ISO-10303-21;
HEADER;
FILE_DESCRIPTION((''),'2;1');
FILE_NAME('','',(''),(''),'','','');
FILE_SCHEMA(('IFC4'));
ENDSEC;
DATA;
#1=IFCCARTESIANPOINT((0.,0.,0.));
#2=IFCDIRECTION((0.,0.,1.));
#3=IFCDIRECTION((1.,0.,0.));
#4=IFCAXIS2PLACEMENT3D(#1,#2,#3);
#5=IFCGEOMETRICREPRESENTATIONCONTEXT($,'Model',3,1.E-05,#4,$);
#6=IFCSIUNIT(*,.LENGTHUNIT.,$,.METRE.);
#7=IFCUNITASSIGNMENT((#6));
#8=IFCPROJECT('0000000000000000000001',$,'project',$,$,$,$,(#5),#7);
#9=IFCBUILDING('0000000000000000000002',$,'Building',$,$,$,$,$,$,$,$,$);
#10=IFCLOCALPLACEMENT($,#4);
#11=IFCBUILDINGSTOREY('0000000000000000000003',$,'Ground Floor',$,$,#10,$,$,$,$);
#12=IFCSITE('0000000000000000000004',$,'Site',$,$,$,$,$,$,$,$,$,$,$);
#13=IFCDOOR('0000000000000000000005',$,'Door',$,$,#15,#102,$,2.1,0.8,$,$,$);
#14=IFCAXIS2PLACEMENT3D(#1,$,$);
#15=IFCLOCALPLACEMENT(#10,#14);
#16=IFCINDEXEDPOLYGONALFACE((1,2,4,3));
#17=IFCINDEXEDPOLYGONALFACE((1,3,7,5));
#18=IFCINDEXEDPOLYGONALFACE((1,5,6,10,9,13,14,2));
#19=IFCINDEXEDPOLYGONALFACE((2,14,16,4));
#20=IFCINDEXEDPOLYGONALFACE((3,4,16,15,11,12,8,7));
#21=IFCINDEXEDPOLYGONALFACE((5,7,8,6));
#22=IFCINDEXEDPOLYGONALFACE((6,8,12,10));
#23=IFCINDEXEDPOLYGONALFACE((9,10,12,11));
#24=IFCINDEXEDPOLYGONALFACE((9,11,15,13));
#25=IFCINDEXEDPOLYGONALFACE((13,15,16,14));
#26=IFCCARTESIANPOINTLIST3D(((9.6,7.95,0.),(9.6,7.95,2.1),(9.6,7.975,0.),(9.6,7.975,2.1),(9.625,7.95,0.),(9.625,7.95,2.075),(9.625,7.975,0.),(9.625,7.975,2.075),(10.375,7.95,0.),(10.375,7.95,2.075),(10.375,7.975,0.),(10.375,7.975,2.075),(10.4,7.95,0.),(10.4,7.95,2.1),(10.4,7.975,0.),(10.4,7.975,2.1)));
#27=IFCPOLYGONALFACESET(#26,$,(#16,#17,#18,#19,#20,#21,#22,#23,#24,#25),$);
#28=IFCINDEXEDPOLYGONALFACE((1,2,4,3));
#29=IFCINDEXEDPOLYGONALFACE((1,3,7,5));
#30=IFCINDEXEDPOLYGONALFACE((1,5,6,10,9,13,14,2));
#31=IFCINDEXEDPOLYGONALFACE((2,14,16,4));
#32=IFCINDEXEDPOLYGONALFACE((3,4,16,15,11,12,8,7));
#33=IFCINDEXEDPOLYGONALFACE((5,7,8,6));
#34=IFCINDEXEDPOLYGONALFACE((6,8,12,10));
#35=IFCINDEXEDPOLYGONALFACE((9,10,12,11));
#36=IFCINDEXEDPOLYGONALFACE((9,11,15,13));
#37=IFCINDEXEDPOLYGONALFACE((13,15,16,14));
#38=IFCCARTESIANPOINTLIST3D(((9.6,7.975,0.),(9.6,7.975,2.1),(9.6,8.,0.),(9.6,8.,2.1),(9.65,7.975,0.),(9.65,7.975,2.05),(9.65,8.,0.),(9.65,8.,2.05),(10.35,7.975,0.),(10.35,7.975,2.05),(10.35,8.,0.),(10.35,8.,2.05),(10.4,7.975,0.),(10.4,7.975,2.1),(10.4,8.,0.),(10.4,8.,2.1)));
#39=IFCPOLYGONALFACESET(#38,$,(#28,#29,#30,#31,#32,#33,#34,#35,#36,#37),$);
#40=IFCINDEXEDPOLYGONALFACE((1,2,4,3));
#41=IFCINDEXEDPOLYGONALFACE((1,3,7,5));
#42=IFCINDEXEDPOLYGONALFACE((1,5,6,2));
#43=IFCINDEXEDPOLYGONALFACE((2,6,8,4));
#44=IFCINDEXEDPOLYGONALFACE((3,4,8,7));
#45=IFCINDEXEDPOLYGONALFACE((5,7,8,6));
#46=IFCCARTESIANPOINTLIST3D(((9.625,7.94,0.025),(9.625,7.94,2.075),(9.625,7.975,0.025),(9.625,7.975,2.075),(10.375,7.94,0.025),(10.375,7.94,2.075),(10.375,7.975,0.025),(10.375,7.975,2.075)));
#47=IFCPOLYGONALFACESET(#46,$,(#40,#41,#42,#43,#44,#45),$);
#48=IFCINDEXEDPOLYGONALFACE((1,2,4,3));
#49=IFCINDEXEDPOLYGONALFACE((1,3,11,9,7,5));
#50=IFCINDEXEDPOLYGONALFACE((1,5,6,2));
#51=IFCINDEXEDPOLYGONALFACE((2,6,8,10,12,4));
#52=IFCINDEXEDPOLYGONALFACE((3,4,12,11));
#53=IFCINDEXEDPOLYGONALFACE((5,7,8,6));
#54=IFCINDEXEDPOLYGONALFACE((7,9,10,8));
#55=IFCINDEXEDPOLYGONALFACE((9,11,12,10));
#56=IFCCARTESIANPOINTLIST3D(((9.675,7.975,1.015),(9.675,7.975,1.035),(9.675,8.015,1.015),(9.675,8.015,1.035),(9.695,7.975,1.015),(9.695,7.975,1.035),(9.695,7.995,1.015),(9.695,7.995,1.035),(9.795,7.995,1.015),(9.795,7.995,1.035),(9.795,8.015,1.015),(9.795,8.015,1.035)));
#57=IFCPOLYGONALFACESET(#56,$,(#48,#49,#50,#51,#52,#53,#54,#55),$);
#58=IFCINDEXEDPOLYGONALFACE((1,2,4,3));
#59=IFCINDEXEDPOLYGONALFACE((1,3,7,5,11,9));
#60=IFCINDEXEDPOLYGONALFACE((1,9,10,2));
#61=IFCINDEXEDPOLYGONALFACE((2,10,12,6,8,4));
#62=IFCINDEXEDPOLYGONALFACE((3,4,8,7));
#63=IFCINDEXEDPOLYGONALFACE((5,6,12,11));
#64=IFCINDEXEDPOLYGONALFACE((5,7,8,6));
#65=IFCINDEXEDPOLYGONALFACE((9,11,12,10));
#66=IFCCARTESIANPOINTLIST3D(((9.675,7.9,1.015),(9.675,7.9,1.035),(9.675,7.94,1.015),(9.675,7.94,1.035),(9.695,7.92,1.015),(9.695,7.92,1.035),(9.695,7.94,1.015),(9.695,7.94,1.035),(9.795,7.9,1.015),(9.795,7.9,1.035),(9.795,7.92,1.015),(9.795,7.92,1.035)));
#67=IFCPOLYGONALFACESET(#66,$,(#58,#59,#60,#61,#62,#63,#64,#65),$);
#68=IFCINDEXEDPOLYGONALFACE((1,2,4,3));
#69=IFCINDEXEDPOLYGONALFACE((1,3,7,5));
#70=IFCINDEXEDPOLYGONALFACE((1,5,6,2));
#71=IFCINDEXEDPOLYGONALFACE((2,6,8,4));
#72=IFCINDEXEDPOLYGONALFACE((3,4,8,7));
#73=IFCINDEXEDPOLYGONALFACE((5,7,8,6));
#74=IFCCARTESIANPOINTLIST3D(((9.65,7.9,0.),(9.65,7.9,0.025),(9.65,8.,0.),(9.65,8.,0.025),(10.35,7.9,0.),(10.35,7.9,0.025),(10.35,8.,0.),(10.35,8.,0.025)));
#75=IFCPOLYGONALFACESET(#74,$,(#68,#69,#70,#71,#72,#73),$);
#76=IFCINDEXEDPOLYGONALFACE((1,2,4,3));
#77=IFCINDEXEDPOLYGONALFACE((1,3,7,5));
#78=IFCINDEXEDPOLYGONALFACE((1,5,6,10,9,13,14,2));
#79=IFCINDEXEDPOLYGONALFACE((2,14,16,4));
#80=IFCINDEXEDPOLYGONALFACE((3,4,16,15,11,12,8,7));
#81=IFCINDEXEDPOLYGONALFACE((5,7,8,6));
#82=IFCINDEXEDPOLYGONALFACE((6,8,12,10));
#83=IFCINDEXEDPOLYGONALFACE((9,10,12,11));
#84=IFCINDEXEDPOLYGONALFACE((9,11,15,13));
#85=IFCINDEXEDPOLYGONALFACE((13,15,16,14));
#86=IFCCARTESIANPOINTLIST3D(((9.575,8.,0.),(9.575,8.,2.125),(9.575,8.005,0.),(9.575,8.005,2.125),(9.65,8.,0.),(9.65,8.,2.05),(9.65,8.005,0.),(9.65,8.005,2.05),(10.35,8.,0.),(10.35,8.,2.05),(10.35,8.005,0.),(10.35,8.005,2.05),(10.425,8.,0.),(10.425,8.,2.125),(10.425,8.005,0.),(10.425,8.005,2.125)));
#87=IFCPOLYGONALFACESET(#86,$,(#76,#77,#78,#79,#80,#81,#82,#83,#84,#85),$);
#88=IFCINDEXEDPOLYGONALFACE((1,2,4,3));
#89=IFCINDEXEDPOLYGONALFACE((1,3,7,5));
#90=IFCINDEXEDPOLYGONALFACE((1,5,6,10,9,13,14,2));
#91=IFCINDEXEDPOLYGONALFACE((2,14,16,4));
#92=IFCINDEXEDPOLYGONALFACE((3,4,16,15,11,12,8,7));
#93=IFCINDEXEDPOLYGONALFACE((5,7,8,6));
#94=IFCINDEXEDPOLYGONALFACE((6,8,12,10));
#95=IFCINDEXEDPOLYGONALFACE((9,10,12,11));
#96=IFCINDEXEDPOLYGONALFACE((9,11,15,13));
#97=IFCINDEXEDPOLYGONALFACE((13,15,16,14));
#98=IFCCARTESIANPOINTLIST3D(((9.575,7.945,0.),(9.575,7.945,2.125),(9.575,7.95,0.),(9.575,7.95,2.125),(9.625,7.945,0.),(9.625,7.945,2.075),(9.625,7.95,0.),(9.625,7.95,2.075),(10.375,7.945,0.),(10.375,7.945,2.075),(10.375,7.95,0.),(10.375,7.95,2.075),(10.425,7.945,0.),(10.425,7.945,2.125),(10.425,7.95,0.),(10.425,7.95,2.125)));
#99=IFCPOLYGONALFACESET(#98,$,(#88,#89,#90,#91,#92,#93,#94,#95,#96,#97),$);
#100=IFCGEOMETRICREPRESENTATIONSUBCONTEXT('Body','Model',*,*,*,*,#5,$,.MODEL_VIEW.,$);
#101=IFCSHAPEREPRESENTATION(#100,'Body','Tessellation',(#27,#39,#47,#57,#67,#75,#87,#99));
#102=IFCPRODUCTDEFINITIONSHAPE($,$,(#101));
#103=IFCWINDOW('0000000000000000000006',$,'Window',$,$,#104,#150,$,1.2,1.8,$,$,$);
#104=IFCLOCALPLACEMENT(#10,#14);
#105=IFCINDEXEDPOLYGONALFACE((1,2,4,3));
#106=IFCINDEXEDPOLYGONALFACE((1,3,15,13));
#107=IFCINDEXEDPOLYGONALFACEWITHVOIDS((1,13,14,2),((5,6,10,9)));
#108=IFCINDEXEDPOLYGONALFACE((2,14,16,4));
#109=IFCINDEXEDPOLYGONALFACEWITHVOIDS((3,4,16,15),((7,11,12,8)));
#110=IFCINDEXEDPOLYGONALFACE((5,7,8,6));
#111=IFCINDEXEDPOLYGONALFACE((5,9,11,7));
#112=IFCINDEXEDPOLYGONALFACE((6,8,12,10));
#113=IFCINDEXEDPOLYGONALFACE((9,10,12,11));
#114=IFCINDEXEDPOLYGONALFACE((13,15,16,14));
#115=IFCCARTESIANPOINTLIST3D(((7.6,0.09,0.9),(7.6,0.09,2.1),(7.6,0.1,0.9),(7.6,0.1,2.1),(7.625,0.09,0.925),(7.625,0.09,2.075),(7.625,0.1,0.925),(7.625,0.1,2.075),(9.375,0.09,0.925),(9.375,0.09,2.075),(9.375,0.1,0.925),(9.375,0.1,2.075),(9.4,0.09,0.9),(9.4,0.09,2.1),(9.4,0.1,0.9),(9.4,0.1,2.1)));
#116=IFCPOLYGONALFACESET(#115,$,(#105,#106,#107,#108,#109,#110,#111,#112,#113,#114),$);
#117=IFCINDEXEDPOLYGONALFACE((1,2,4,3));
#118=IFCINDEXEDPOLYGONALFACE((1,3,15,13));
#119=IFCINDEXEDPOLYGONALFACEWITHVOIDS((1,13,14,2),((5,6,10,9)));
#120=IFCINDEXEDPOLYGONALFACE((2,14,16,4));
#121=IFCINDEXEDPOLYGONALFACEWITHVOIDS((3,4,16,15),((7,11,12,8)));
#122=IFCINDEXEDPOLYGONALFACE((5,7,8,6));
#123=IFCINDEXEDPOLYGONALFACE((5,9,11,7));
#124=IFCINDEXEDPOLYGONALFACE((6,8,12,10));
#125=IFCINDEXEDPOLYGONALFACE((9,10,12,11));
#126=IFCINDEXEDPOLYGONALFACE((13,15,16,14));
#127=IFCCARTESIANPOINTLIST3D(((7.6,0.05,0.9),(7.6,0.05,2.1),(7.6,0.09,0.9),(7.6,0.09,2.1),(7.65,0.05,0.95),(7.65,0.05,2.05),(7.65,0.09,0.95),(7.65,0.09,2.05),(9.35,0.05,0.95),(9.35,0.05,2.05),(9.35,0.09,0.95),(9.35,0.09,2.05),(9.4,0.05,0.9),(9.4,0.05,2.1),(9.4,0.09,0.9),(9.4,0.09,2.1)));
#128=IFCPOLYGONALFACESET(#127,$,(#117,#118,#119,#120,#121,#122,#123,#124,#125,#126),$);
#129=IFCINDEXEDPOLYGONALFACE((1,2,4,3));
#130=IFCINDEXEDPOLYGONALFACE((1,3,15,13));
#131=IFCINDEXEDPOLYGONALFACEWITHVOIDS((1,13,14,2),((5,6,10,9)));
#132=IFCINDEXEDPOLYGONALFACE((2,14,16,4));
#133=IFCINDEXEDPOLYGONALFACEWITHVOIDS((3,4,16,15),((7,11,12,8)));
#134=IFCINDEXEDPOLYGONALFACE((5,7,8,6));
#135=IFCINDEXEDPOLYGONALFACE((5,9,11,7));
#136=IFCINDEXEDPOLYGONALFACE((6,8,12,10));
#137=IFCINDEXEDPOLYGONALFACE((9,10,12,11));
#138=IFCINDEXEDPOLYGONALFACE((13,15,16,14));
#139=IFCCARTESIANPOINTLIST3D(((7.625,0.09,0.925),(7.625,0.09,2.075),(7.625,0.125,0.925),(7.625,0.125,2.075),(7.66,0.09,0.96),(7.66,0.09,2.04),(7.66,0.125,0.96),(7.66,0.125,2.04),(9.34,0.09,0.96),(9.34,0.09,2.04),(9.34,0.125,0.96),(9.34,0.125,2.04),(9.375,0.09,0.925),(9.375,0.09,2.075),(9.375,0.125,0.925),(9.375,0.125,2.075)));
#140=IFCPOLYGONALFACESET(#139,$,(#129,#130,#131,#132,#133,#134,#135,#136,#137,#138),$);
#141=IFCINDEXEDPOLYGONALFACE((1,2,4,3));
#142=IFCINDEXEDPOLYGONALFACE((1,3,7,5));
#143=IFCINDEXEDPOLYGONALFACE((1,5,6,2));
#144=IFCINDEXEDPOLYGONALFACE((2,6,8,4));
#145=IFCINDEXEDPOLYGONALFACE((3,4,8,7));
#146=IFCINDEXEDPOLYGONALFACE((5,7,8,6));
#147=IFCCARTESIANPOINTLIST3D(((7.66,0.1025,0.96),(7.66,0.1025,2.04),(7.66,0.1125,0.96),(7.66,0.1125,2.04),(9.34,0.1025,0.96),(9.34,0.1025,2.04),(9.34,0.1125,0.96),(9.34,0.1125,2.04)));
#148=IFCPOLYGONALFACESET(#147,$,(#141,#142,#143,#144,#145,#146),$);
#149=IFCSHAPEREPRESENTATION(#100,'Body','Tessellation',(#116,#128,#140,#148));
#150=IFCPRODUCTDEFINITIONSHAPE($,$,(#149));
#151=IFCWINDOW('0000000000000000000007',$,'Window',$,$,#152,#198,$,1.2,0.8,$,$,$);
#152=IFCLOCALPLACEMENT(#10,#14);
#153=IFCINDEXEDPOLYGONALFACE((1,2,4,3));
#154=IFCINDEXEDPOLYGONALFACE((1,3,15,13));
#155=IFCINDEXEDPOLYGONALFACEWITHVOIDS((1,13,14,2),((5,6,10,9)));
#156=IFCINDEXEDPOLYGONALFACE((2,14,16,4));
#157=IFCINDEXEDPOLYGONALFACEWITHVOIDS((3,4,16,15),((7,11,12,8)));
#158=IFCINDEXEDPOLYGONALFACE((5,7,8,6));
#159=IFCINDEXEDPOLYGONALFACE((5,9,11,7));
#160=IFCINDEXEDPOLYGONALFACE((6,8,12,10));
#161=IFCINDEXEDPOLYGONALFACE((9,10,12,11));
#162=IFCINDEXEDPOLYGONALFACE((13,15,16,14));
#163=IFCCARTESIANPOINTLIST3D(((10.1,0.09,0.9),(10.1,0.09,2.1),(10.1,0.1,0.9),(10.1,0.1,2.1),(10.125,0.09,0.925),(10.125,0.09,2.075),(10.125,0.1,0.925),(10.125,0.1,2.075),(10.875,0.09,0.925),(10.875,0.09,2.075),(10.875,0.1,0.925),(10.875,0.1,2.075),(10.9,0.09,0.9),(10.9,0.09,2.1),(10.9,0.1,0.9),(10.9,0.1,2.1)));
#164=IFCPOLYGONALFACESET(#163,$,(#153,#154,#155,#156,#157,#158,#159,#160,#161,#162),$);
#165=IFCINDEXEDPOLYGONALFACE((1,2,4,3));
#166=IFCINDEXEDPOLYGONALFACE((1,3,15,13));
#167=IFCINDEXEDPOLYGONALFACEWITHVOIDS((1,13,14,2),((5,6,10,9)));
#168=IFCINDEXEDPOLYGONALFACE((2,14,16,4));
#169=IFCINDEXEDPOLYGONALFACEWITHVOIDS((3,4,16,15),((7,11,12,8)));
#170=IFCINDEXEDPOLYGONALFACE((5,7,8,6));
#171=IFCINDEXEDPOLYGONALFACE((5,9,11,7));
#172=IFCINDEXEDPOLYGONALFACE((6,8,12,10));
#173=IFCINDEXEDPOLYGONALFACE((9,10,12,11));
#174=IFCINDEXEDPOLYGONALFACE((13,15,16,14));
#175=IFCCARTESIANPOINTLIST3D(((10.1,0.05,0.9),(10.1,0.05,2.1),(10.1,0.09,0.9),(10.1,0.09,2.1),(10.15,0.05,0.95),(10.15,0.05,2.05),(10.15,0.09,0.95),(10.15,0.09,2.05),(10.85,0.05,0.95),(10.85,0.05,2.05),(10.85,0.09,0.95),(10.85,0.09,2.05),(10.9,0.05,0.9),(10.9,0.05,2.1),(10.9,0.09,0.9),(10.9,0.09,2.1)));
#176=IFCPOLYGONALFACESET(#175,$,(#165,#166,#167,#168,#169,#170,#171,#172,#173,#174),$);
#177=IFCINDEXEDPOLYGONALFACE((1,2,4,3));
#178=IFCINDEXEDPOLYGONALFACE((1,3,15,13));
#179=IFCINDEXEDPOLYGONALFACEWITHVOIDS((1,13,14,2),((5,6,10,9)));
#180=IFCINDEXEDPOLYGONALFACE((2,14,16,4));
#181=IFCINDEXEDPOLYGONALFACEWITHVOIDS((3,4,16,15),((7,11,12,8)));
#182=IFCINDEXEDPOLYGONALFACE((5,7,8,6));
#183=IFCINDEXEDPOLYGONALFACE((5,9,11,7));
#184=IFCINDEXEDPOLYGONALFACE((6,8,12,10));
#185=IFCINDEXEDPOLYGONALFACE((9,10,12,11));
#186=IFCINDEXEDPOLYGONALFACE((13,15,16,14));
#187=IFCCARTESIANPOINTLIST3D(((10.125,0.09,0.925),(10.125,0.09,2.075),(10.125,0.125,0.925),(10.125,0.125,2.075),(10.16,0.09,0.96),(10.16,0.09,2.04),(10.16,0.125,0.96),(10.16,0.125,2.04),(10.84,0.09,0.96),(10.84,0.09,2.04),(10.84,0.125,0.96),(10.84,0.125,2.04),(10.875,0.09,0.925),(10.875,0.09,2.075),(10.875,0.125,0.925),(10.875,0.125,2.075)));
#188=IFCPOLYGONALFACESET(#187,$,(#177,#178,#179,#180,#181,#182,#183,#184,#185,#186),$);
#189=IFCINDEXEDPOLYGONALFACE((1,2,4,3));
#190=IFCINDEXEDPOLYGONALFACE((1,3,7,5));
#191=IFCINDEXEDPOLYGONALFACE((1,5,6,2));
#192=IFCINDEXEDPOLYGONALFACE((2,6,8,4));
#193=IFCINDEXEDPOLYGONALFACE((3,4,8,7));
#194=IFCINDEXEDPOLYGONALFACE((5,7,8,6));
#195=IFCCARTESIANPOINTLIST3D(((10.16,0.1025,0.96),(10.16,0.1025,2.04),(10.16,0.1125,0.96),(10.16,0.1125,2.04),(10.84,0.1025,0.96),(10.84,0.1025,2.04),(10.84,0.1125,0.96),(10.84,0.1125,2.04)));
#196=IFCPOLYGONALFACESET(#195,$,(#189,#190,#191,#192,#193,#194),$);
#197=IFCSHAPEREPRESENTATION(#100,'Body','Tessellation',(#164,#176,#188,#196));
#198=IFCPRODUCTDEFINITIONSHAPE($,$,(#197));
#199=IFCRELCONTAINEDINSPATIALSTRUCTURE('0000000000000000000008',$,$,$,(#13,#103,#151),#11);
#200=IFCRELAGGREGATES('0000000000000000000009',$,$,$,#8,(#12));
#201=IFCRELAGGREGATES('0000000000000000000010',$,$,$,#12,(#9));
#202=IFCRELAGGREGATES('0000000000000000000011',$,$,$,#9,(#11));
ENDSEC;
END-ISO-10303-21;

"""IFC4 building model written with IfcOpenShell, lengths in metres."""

from ifc_helpers import new_model, si_unit, frame, origin_with_axes, place, context, subcontext, project, spatial, line, indexed_curve, outline, extrude, element, save


model = new_model("IFC4")

# Units and contexts
model_context = context("Model", 3, precision=1e-05, world=origin_with_axes())
body_context = subcontext(model_context, "Body", "Model", "MODEL_VIEW")
ifc_project = project(units=[si_unit("LENGTHUNIT", "METRE")], contexts=[model_context])

# Site, building, storey
site = spatial("IfcSite", under=ifc_project, Name="Site")
building = spatial("IfcBuilding", under=site, Name="Building")
storey_placement = place(None, origin_with_axes())
storey = spatial("IfcBuildingStorey", under=building, at=storey_placement, Name="Ground Floor")

# Door
door_1_placement = place(storey_placement, frame((10.4, 8.0, 0.0), z_axis=(0.0, 0.0, 1.0), x_axis=(-1.0, 0.0, 0.0)))
element("IfcDoor", 1, at=door_1_placement, inside=storey, Name="Door", OverallHeight=2.1, OverallWidth=0.8, context=body_context, shape_type="SweptSolid", body=[
    extrude(outline(indexed_curve([(0.0, 0.0), (0.0, 2.1), (0.8, 2.1), (0.8, 0.0), (0.775, 0.0), (0.775, 2.075), (0.025, 2.075), (0.025, 0.0)], segments=[line(1, 2, 3, 4, 5, 6, 7, 8, 1)])), frame((0.0, 0.025, 0.0), z_axis=(0.0, -1.0, 0.0), x_axis=(1.0, 0.0, 0.0)), (0.0, 0.0, -1.0), 0.025),
    extrude(outline(indexed_curve([(0.0, 0.0), (0.0, 2.1), (0.8, 2.1), (0.8, 0.0), (0.75, 0.0), (0.75, 2.05), (0.05, 2.05), (0.05, 0.0)], segments=[line(1, 2, 3, 4, 5, 6, 7, 8, 1)])), frame((0.0, 0.0, 0.0), z_axis=(0.0, -1.0, 0.0), x_axis=(1.0, 0.0, 0.0)), (0.0, 0.0, -1.0), 0.025),
    extrude(outline(indexed_curve([(0.0, 0.0), (0.75, 0.0), (0.75, 0.035), (0.0, 0.035)], segments=[line(1, 2, 3, 4, 1)])), frame((0.025, 0.025, 0.025), z_axis=(0.0, 0.0, 1.0), x_axis=(1.0, 0.0, 0.0)), (0.0, 0.0, 1.0), 2.05),
    extrude(outline(indexed_curve([(0.0, 0.0), (0.0, -0.04), (-0.12, -0.04), (-0.12, -0.02), (-0.02, -0.02), (-0.02, 0.0)], segments=[line(1, 2, 3, 4, 5, 6, 1)])), frame((0.725, 0.025, 1.015), z_axis=(0.0, 0.0, 1.0), x_axis=(1.0, 0.0, 0.0)), (0.0, 0.0, 1.0), 0.02),
    extrude(outline(indexed_curve([(0.0, 0.0), (0.0, 0.04), (-0.12, 0.04), (-0.12, 0.02), (-0.02, 0.02), (-0.02, 0.0)], segments=[line(1, 2, 3, 4, 5, 6, 1)])), frame((0.725, 0.06, 1.015), z_axis=(0.0, 0.0, 1.0), x_axis=(1.0, 0.0, 0.0)), (0.0, 0.0, 1.0), 0.02),
    extrude(outline(indexed_curve([(0.0, 0.0), (0.7, 0.0), (0.7, 0.1), (0.0, 0.1)], segments=[line(1, 2, 3, 4, 1)])), frame((0.05, 0.0, 0.0), z_axis=(0.0, 0.0, 1.0), x_axis=(1.0, 0.0, 0.0)), (0.0, 0.0, 1.0), 0.025),
    extrude(outline(indexed_curve([(0.0, 0.0), (0.0, 2.125), (0.85, 2.125), (0.85, 0.0), (0.775, 0.0), (0.775, 2.05), (0.075, 2.05), (0.075, 0.0)], segments=[line(1, 2, 3, 4, 5, 6, 7, 8, 1)])), frame((-0.025, -0.005, 0.0), z_axis=(0.0, -1.0, 0.0), x_axis=(1.0, 0.0, 0.0)), (0.0, 0.0, -1.0), 0.005),
    extrude(outline(indexed_curve([(0.0, 0.0), (0.0, 2.125), (0.85, 2.125), (0.85, 0.0), (0.8, 0.0), (0.8, 2.075), (0.05, 2.075), (0.05, 0.0)], segments=[line(1, 2, 3, 4, 5, 6, 7, 8, 1)])), frame((-0.025, 0.05, 0.0), z_axis=(0.0, -1.0, 0.0), x_axis=(1.0, 0.0, 0.0)), (0.0, 0.0, -1.0), 0.005),
])

# Windows
window_1_placement = place(storey_placement, frame((7.6, 0.0, 0.9), z_axis=(0.0, 0.0, 1.0), x_axis=(1.0, 0.0, 0.0)))
element("IfcWindow", 2, at=window_1_placement, inside=storey, Name="Window", OverallHeight=1.2, OverallWidth=1.8, context=body_context, shape_type="SweptSolid", body=[
    extrude(outline(indexed_curve([(0.0, 0.0), (1.8, 0.0), (1.8, 1.2), (0.0, 1.2)], segments=[line(1, 2, 3, 4, 1)]), holes=[indexed_curve([(0.025, 0.025), (1.775, 0.025), (1.775, 1.175), (0.025, 1.175)], segments=[line(1, 2, 3, 4, 1)])]), frame((0.0, 0.09, 0.0), z_axis=(0.0, -1.0, 0.0), x_axis=(1.0, 0.0, 0.0)), (0.0, 0.0, -1.0), 0.01),
    extrude(outline(indexed_curve([(0.0, 0.0), (1.8, 0.0), (1.8, 1.2), (0.0, 1.2)], segments=[line(1, 2, 3, 4, 1)]), holes=[indexed_curve([(0.05, 0.05), (1.75, 0.05), (1.75, 1.15), (0.05, 1.15)], segments=[line(1, 2, 3, 4, 1)])]), frame((0.0, 0.05, 0.0), z_axis=(0.0, -1.0, 0.0), x_axis=(1.0, 0.0, 0.0)), (0.0, 0.0, -1.0), 0.04),
    extrude(outline(indexed_curve([(0.0, 0.0), (1.75, 0.0), (1.75, 1.15), (0.0, 1.15)], segments=[line(1, 2, 3, 4, 1)]), holes=[indexed_curve([(0.035, 0.035), (1.715, 0.035), (1.715, 1.115), (0.035, 1.115)], segments=[line(1, 2, 3, 4, 1)])]), frame((0.025, 0.09, 0.025), z_axis=(0.0, -1.0, 0.0), x_axis=(1.0, 0.0, 0.0)), (0.0, 0.0, -1.0), 0.035),
    extrude(outline(indexed_curve([(0.035, 0.035), (1.715, 0.035), (1.715, 1.115), (0.035, 1.115)], segments=[line(1, 2, 3, 4, 1)])), frame((0.025, 0.1025, 0.025), z_axis=(0.0, -1.0, 0.0), x_axis=(1.0, 0.0, 0.0)), (0.0, 0.0, -1.0), 0.01),
])
window_2_placement = place(storey_placement, frame((10.1, 0.0, 0.9), z_axis=(0.0, 0.0, 1.0), x_axis=(1.0, 0.0, 0.0)))
element("IfcWindow", 3, at=window_2_placement, inside=storey, Name="Window", OverallHeight=1.2, OverallWidth=0.8, context=body_context, shape_type="SweptSolid", body=[
    extrude(outline(indexed_curve([(0.0, 0.0), (0.8, 0.0), (0.8, 1.2), (0.0, 1.2)], segments=[line(1, 2, 3, 4, 1)]), holes=[indexed_curve([(0.025, 0.025), (0.775, 0.025), (0.775, 1.175), (0.025, 1.175)], segments=[line(1, 2, 3, 4, 1)])]), frame((0.0, 0.09, 0.0), z_axis=(0.0, -1.0, 0.0), x_axis=(1.0, 0.0, 0.0)), (0.0, 0.0, -1.0), 0.01),
    extrude(outline(indexed_curve([(0.0, 0.0), (0.8, 0.0), (0.8, 1.2), (0.0, 1.2)], segments=[line(1, 2, 3, 4, 1)]), holes=[indexed_curve([(0.05, 0.05), (0.75, 0.05), (0.75, 1.15), (0.05, 1.15)], segments=[line(1, 2, 3, 4, 1)])]), frame((0.0, 0.05, 0.0), z_axis=(0.0, -1.0, 0.0), x_axis=(1.0, 0.0, 0.0)), (0.0, 0.0, -1.0), 0.04),
    extrude(outline(indexed_curve([(0.0, 0.0), (0.75, 0.0), (0.75, 1.15), (0.0, 1.15)], segments=[line(1, 2, 3, 4, 1)]), holes=[indexed_curve([(0.035, 0.035), (0.715, 0.035), (0.715, 1.115), (0.035, 1.115)], segments=[line(1, 2, 3, 4, 1)])]), frame((0.025, 0.09, 0.025), z_axis=(0.0, -1.0, 0.0), x_axis=(1.0, 0.0, 0.0)), (0.0, 0.0, -1.0), 0.035),
    extrude(outline(indexed_curve([(0.035, 0.035), (0.715, 0.035), (0.715, 1.115), (0.035, 1.115)], segments=[line(1, 2, 3, 4, 1)])), frame((0.025, 0.1025, 0.025), z_axis=(0.0, -1.0, 0.0), x_axis=(1.0, 0.0, 0.0)), (0.0, 0.0, -1.0), 0.01),
])

save(model, "model.ifc")
